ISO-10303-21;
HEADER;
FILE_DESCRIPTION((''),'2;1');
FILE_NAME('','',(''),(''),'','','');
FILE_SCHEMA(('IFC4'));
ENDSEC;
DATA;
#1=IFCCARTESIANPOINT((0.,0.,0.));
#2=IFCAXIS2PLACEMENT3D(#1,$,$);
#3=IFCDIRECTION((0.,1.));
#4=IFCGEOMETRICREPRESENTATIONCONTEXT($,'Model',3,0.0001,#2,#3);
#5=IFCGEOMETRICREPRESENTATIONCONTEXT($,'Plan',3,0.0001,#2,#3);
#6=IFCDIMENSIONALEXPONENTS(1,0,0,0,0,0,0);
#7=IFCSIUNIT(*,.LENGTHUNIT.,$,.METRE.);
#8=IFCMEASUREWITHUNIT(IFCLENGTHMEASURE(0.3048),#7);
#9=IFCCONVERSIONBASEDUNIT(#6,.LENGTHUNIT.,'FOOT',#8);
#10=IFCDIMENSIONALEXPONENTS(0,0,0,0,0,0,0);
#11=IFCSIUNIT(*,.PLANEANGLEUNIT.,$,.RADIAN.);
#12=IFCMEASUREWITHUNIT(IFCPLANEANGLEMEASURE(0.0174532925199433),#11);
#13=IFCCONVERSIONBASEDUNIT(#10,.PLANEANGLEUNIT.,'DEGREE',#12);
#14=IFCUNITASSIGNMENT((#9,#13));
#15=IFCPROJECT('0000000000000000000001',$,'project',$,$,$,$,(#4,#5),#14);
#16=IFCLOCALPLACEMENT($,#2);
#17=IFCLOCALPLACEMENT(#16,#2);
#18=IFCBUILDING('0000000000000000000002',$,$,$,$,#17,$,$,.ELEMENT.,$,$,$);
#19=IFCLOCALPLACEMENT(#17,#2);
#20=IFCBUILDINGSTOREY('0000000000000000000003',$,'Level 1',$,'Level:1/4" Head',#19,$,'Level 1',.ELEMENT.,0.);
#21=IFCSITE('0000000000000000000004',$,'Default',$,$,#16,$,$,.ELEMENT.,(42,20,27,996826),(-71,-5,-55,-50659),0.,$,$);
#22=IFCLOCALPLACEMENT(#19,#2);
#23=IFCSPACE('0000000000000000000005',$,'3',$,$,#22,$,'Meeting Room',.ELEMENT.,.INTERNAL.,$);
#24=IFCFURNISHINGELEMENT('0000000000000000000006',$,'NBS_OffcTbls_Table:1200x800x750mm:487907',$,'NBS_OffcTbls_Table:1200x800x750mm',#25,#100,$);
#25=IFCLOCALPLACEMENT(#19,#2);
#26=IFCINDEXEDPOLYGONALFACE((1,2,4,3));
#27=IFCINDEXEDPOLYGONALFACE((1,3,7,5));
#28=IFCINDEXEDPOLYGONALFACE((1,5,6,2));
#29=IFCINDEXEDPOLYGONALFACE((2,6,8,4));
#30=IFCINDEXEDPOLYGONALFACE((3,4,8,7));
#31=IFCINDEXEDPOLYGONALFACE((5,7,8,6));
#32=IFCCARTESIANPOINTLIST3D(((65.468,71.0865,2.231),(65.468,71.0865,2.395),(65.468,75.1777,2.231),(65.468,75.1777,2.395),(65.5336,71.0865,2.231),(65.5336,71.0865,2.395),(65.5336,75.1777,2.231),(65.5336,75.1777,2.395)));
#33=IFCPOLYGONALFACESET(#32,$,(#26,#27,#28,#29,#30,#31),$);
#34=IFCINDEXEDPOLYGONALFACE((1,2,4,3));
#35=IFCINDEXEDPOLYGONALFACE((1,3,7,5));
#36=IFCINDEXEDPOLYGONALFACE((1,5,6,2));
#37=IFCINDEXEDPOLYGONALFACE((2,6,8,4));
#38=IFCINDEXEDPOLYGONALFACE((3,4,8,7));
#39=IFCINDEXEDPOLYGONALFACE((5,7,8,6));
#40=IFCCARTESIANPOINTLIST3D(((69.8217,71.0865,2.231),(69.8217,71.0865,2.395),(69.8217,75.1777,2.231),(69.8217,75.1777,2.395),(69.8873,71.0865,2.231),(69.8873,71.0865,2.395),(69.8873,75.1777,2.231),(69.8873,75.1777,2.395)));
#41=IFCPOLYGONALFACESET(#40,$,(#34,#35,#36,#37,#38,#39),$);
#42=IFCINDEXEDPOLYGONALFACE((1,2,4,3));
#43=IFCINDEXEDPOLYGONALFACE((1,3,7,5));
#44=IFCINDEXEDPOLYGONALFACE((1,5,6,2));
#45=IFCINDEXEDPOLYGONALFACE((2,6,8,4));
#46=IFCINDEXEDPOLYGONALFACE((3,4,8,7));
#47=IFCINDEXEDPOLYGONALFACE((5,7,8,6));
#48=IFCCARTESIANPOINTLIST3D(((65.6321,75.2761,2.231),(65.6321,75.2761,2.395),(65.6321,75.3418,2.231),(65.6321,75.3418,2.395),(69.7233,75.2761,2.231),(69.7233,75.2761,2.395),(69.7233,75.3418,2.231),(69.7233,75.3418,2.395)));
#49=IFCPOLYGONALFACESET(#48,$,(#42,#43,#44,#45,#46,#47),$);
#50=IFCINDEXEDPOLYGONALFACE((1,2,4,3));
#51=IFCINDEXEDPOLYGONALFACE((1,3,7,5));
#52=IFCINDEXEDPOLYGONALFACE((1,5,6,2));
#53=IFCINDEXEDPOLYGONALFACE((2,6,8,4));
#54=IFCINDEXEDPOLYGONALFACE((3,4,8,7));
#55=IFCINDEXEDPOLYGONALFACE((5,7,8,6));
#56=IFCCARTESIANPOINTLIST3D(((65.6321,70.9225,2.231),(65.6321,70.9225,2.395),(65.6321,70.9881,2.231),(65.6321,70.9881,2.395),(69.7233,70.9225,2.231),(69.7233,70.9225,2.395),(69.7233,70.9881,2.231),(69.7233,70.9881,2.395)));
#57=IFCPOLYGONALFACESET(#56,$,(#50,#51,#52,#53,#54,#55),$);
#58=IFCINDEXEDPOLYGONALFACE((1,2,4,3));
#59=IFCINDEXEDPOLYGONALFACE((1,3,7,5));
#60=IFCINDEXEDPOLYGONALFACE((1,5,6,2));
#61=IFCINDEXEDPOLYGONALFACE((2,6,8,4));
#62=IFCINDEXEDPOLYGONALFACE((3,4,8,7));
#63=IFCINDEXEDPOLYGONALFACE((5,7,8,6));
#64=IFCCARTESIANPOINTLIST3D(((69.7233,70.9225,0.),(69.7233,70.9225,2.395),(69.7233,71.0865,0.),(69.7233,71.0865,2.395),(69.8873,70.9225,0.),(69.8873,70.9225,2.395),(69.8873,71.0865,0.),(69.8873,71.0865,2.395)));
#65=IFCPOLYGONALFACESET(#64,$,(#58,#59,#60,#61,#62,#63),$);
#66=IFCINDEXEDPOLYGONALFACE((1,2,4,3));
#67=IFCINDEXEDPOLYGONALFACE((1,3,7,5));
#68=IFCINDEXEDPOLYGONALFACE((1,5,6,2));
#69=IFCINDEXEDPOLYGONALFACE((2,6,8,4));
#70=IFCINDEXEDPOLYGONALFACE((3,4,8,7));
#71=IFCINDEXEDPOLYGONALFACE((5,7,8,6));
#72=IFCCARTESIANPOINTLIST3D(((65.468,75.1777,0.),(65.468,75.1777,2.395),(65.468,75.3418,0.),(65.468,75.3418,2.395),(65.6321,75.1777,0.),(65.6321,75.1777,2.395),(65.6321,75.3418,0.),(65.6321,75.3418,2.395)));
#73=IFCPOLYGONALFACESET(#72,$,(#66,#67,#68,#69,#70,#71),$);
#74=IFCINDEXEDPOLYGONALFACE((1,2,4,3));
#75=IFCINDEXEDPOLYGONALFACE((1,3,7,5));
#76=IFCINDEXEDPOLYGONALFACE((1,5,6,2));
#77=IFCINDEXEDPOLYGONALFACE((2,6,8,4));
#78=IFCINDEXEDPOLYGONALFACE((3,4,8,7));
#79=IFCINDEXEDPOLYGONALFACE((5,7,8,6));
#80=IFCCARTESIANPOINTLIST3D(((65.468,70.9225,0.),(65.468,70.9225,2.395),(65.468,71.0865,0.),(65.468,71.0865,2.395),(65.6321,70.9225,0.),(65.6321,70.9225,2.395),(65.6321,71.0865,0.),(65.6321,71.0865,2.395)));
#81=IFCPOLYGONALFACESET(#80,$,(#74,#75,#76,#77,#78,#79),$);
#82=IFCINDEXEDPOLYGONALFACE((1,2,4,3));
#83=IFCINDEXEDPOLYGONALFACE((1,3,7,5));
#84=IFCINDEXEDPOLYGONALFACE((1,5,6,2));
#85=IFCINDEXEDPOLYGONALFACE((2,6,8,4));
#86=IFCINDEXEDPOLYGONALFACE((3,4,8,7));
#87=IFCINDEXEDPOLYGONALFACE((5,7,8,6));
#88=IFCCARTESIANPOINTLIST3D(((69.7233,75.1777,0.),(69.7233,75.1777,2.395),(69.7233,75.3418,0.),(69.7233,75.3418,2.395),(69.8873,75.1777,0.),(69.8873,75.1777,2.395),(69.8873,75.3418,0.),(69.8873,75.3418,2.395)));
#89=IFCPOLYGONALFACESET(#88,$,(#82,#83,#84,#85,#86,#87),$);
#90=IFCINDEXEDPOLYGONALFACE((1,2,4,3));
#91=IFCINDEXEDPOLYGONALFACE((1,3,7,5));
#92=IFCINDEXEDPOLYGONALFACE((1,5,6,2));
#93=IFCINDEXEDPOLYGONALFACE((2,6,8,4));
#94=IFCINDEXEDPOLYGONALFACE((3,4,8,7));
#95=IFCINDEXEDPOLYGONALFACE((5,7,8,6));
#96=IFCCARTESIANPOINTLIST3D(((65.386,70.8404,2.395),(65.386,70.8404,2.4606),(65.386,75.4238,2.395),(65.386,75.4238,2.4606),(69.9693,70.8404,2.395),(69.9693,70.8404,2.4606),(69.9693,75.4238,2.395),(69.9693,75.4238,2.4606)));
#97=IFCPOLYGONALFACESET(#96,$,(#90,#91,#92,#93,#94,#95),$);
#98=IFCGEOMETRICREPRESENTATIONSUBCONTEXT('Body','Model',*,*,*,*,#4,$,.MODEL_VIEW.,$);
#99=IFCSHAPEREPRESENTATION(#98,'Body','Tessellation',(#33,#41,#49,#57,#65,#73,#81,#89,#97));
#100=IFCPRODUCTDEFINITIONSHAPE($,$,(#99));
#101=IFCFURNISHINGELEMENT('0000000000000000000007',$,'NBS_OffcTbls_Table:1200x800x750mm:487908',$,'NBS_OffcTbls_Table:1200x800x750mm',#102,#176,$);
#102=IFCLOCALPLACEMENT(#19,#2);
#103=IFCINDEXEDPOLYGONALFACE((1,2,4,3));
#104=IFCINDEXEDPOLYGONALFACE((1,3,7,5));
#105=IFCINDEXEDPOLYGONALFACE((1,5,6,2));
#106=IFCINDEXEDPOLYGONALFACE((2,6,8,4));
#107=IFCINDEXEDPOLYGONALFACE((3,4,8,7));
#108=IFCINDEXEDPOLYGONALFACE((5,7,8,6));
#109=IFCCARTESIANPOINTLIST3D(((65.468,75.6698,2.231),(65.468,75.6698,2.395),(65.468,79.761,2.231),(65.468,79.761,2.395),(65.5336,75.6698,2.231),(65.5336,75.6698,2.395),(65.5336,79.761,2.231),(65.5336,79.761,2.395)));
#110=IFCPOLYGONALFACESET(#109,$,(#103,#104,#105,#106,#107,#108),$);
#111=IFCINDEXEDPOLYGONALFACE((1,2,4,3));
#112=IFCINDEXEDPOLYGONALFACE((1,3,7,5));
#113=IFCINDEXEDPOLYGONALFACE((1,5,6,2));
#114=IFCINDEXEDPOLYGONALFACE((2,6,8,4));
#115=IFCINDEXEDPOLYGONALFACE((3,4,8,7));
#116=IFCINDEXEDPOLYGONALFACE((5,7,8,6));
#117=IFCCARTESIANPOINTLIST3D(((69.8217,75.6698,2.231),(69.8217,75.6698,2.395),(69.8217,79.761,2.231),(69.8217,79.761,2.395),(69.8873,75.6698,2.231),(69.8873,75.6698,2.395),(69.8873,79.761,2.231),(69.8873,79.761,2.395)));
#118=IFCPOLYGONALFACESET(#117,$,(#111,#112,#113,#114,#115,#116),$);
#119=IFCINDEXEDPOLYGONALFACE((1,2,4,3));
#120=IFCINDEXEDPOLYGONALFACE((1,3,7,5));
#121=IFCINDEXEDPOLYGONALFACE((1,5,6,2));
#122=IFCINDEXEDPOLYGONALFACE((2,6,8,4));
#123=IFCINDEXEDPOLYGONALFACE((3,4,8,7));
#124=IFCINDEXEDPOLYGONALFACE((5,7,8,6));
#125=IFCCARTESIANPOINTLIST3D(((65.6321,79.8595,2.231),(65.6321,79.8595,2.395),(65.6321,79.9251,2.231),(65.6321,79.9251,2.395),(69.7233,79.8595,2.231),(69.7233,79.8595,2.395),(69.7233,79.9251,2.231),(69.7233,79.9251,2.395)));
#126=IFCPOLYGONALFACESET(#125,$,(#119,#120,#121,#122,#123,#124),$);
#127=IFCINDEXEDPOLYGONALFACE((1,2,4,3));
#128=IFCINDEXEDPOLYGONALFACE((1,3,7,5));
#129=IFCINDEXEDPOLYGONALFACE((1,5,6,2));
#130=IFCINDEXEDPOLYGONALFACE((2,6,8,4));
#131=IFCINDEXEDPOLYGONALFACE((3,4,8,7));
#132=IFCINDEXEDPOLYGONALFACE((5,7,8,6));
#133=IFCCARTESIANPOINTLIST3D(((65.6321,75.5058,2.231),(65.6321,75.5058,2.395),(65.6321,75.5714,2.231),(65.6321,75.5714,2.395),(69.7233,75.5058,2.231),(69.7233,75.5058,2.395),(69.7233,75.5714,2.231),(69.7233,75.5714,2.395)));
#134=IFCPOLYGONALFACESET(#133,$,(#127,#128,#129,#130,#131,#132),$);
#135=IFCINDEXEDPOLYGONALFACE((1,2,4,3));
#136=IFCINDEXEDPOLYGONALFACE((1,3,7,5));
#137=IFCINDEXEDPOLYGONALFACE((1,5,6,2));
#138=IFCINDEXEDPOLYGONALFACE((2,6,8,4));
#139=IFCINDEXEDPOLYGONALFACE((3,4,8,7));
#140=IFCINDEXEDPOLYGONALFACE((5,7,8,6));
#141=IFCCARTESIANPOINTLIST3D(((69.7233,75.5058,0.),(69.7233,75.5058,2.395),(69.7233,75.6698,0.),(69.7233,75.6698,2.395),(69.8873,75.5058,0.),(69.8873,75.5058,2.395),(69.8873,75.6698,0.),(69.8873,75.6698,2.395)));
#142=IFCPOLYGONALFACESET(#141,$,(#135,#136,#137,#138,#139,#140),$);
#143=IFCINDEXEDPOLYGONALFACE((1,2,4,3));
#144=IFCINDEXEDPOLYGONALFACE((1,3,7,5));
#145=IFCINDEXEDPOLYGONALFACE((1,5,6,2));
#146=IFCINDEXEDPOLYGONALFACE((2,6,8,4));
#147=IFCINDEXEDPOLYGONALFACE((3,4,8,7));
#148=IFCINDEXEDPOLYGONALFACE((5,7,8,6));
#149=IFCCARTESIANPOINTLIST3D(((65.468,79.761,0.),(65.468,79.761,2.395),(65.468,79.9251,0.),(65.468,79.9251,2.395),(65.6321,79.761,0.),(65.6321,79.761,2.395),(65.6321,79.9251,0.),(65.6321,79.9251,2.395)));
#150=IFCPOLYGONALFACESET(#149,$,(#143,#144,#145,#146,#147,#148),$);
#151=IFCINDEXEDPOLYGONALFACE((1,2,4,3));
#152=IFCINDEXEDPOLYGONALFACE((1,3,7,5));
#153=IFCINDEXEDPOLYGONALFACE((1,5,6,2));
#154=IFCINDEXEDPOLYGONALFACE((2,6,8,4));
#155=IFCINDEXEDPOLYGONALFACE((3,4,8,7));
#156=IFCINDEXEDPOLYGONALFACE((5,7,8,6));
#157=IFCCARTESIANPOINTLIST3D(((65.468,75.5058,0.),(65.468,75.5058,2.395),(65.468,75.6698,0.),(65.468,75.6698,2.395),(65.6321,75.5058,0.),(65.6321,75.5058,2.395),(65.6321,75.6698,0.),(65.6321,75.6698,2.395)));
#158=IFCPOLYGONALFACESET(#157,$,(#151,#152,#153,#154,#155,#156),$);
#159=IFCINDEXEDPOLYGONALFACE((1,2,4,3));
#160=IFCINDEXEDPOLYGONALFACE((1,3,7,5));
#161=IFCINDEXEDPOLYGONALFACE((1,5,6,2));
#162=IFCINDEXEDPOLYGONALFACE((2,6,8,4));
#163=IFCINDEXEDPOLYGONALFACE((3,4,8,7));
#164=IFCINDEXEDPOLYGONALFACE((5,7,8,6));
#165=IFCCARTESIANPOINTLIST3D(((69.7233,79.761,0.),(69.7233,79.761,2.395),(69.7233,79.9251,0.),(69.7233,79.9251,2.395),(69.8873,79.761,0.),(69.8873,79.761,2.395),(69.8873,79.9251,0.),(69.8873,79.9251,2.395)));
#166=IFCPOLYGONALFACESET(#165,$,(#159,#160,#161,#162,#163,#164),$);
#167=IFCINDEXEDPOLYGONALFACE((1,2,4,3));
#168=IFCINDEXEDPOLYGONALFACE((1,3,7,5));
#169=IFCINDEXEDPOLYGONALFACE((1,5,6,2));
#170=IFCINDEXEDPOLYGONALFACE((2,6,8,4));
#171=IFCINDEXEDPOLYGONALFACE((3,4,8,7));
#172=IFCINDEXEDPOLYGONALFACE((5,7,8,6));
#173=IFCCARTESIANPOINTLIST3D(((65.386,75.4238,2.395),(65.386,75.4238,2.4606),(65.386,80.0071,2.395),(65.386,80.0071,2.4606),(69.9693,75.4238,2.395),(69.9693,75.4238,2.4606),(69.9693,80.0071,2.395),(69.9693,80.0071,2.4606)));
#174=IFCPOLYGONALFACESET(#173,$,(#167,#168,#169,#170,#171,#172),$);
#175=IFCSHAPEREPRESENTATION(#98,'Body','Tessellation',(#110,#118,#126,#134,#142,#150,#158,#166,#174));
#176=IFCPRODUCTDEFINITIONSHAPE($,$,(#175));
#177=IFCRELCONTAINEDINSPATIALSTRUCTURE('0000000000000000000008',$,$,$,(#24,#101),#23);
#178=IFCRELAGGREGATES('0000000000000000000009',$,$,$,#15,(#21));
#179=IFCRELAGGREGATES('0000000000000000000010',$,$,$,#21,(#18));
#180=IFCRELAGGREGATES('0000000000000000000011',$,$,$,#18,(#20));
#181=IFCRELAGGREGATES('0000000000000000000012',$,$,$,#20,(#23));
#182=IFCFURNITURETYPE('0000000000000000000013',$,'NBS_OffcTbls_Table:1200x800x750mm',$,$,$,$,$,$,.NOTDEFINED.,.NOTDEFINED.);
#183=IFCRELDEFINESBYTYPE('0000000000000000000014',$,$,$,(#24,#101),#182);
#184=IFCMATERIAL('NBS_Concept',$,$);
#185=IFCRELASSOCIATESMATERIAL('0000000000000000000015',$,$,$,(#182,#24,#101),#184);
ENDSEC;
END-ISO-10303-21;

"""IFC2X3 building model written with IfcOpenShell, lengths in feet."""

from ifc_helpers import new_model, entity, si_unit, converted_unit, direction, frame, frame_2d, origin, origin_2d_with_axis, place, context, subcontext, project, spatial, rectangle, extrude, source, transform, mapped, material, type_object, type_shapes, element, save


model = new_model("IFC2X3")

# Units and contexts
model_context = context("Model", 3, precision=0.0001, world=origin(), true_north=direction((0.0, 1.0)))
plan_context = context("Plan", 3, precision=0.0001, world=origin(), true_north=direction((0.0, 1.0)))
body_context = subcontext(model_context, "Body", "Model", "MODEL_VIEW")
ifc_project = project(units=[converted_unit("LENGTHUNIT", "FOOT", entity("IfcLengthMeasure", 0.3048), si_unit("LENGTHUNIT", "METRE"), dimensions=[1, 0, 0, 0, 0, 0, 0]), converted_unit("PLANEANGLEUNIT", "DEGREE", entity("IfcPlaneAngleMeasure", 0.0174532925199433), si_unit("PLANEANGLEUNIT", "RADIAN"), dimensions=[0, 0, 0, 0, 0, 0, 0])], contexts=[model_context, plan_context])

# Site, building, storey
site_placement = place(None, origin())
site = spatial("IfcSite", under=ifc_project, at=site_placement, Name="Default", CompositionType="ELEMENT", RefLatitude=(42, 20, 27, 996826), RefLongitude=(-71, -5, -55, -50659), RefElevation=0.0)
building_placement = place(site_placement, origin())
building = spatial("IfcBuilding", under=site, at=building_placement, CompositionType="ELEMENT")
storey_placement = place(building_placement, origin())
storey = spatial("IfcBuildingStorey", under=building, at=storey_placement, Name="Level 1", ObjectType="Level:1/4\" Head", LongName="Level 1", CompositionType="ELEMENT", Elevation=0.0)

# Shared definitions
space_1_placement = place(storey_placement, origin())
space_1 = spatial("IfcSpace", under=storey, at=space_1_placement, Name="3", LongName="Meeting Room", CompositionType="ELEMENT", InteriorOrExteriorSpace="INTERNAL")

# Furnishing elements
ifc_material_1 = material(Name="NBS_Concept")
furniture_type_1 = type_object("IfcFurnitureType", Name="NBS_OffcTbls_Table:1200x800x750mm", AssemblyPlace="NOTDEFINED", material=ifc_material_1)
shared_shape_1 = source(origin(), body_context, "Body", "SweptSolid", [
    extrude(rectangle(XDim=0.0656, YDim=4.0912, at=frame_2d((0.0, 0.0), x_axis=(1.0, 0.0))), frame((-2.1768, 0.0, 2.231)), (0.0, 0.0, 1.0), 0.164),
    extrude(rectangle(XDim=4.0912, YDim=0.0656, at=frame_2d((0.0, 0.0), x_axis=(1.0, 0.0))), frame((2.1768, 0.0, 2.231), z_axis=(0.0, 0.0, 1.0), x_axis=(0.0, -1.0, 0.0)), (0.0, 0.0, 1.0), 0.164),
    extrude(rectangle(XDim=4.0912, YDim=0.0656, at=origin_2d_with_axis()), frame((0.0, 2.1768, 2.231), z_axis=(0.0, 0.0, 1.0), x_axis=(-1.0, 0.0, 0.0)), (0.0, 0.0, 1.0), 0.164),
    extrude(rectangle(XDim=4.0912, YDim=0.0656, at=origin_2d_with_axis()), frame((0.0, -2.1768, 2.231)), (0.0, 0.0, 1.0), 0.164),
    extrude(rectangle(XDim=0.164, YDim=0.164, at=origin_2d_with_axis()), frame((2.1276, -2.1276, 0.0), z_axis=(0.0, 0.0, 1.0), x_axis=(-1.0, 0.0, 0.0)), (0.0, 0.0, 1.0), 2.395),
    extrude(rectangle(XDim=0.164, YDim=0.164, at=frame_2d((0.0, 0.0), x_axis=(1.0, 0.0))), frame((-2.1276, 2.1276, 0.0), z_axis=(0.0, 0.0, 1.0), x_axis=(-1.0, 0.0, 0.0)), (0.0, 0.0, 1.0), 2.395),
    extrude(rectangle(XDim=0.164, YDim=0.164, at=origin_2d_with_axis()), frame((-2.1276, -2.1276, 0.0), z_axis=(0.0, 0.0, 1.0), x_axis=(-1.0, 0.0, 0.0)), (0.0, 0.0, 1.0), 2.395),
    extrude(rectangle(XDim=0.164, YDim=0.164, at=frame_2d((0.0, 0.0), x_axis=(1.0, 0.0))), frame((2.1276, 2.1276, 0.0)), (0.0, 0.0, 1.0), 2.395),
    extrude(rectangle(XDim=4.5833, YDim=4.5833, at=origin_2d_with_axis()), frame((0.0, 0.0, 2.395)), (0.0, 0.0, 1.0), 0.0656),
])
type_shapes(furniture_type_1, [shared_shape_1])
for number, where, name in (
    (1, (67.6777, 73.1321, 0.0), "NBS_OffcTbls_Table:1200x800x750mm:487907"),
    (2, (67.6777, 77.7154, 0.0), "NBS_OffcTbls_Table:1200x800x750mm:487908"),
):
    element("IfcFurnishingElement", number, at=place(space_1_placement, frame(where)), inside=space_1, type_object=furniture_type_1, material=ifc_material_1, Name=name, ObjectType="NBS_OffcTbls_Table:1200x800x750mm", context=body_context, shape_type="MappedRepresentation", body=[
        mapped(shared_shape_1, transform((0.0, 0.0, 0.0), scale=1.0)),
    ])

save(model, "model.ifc")
